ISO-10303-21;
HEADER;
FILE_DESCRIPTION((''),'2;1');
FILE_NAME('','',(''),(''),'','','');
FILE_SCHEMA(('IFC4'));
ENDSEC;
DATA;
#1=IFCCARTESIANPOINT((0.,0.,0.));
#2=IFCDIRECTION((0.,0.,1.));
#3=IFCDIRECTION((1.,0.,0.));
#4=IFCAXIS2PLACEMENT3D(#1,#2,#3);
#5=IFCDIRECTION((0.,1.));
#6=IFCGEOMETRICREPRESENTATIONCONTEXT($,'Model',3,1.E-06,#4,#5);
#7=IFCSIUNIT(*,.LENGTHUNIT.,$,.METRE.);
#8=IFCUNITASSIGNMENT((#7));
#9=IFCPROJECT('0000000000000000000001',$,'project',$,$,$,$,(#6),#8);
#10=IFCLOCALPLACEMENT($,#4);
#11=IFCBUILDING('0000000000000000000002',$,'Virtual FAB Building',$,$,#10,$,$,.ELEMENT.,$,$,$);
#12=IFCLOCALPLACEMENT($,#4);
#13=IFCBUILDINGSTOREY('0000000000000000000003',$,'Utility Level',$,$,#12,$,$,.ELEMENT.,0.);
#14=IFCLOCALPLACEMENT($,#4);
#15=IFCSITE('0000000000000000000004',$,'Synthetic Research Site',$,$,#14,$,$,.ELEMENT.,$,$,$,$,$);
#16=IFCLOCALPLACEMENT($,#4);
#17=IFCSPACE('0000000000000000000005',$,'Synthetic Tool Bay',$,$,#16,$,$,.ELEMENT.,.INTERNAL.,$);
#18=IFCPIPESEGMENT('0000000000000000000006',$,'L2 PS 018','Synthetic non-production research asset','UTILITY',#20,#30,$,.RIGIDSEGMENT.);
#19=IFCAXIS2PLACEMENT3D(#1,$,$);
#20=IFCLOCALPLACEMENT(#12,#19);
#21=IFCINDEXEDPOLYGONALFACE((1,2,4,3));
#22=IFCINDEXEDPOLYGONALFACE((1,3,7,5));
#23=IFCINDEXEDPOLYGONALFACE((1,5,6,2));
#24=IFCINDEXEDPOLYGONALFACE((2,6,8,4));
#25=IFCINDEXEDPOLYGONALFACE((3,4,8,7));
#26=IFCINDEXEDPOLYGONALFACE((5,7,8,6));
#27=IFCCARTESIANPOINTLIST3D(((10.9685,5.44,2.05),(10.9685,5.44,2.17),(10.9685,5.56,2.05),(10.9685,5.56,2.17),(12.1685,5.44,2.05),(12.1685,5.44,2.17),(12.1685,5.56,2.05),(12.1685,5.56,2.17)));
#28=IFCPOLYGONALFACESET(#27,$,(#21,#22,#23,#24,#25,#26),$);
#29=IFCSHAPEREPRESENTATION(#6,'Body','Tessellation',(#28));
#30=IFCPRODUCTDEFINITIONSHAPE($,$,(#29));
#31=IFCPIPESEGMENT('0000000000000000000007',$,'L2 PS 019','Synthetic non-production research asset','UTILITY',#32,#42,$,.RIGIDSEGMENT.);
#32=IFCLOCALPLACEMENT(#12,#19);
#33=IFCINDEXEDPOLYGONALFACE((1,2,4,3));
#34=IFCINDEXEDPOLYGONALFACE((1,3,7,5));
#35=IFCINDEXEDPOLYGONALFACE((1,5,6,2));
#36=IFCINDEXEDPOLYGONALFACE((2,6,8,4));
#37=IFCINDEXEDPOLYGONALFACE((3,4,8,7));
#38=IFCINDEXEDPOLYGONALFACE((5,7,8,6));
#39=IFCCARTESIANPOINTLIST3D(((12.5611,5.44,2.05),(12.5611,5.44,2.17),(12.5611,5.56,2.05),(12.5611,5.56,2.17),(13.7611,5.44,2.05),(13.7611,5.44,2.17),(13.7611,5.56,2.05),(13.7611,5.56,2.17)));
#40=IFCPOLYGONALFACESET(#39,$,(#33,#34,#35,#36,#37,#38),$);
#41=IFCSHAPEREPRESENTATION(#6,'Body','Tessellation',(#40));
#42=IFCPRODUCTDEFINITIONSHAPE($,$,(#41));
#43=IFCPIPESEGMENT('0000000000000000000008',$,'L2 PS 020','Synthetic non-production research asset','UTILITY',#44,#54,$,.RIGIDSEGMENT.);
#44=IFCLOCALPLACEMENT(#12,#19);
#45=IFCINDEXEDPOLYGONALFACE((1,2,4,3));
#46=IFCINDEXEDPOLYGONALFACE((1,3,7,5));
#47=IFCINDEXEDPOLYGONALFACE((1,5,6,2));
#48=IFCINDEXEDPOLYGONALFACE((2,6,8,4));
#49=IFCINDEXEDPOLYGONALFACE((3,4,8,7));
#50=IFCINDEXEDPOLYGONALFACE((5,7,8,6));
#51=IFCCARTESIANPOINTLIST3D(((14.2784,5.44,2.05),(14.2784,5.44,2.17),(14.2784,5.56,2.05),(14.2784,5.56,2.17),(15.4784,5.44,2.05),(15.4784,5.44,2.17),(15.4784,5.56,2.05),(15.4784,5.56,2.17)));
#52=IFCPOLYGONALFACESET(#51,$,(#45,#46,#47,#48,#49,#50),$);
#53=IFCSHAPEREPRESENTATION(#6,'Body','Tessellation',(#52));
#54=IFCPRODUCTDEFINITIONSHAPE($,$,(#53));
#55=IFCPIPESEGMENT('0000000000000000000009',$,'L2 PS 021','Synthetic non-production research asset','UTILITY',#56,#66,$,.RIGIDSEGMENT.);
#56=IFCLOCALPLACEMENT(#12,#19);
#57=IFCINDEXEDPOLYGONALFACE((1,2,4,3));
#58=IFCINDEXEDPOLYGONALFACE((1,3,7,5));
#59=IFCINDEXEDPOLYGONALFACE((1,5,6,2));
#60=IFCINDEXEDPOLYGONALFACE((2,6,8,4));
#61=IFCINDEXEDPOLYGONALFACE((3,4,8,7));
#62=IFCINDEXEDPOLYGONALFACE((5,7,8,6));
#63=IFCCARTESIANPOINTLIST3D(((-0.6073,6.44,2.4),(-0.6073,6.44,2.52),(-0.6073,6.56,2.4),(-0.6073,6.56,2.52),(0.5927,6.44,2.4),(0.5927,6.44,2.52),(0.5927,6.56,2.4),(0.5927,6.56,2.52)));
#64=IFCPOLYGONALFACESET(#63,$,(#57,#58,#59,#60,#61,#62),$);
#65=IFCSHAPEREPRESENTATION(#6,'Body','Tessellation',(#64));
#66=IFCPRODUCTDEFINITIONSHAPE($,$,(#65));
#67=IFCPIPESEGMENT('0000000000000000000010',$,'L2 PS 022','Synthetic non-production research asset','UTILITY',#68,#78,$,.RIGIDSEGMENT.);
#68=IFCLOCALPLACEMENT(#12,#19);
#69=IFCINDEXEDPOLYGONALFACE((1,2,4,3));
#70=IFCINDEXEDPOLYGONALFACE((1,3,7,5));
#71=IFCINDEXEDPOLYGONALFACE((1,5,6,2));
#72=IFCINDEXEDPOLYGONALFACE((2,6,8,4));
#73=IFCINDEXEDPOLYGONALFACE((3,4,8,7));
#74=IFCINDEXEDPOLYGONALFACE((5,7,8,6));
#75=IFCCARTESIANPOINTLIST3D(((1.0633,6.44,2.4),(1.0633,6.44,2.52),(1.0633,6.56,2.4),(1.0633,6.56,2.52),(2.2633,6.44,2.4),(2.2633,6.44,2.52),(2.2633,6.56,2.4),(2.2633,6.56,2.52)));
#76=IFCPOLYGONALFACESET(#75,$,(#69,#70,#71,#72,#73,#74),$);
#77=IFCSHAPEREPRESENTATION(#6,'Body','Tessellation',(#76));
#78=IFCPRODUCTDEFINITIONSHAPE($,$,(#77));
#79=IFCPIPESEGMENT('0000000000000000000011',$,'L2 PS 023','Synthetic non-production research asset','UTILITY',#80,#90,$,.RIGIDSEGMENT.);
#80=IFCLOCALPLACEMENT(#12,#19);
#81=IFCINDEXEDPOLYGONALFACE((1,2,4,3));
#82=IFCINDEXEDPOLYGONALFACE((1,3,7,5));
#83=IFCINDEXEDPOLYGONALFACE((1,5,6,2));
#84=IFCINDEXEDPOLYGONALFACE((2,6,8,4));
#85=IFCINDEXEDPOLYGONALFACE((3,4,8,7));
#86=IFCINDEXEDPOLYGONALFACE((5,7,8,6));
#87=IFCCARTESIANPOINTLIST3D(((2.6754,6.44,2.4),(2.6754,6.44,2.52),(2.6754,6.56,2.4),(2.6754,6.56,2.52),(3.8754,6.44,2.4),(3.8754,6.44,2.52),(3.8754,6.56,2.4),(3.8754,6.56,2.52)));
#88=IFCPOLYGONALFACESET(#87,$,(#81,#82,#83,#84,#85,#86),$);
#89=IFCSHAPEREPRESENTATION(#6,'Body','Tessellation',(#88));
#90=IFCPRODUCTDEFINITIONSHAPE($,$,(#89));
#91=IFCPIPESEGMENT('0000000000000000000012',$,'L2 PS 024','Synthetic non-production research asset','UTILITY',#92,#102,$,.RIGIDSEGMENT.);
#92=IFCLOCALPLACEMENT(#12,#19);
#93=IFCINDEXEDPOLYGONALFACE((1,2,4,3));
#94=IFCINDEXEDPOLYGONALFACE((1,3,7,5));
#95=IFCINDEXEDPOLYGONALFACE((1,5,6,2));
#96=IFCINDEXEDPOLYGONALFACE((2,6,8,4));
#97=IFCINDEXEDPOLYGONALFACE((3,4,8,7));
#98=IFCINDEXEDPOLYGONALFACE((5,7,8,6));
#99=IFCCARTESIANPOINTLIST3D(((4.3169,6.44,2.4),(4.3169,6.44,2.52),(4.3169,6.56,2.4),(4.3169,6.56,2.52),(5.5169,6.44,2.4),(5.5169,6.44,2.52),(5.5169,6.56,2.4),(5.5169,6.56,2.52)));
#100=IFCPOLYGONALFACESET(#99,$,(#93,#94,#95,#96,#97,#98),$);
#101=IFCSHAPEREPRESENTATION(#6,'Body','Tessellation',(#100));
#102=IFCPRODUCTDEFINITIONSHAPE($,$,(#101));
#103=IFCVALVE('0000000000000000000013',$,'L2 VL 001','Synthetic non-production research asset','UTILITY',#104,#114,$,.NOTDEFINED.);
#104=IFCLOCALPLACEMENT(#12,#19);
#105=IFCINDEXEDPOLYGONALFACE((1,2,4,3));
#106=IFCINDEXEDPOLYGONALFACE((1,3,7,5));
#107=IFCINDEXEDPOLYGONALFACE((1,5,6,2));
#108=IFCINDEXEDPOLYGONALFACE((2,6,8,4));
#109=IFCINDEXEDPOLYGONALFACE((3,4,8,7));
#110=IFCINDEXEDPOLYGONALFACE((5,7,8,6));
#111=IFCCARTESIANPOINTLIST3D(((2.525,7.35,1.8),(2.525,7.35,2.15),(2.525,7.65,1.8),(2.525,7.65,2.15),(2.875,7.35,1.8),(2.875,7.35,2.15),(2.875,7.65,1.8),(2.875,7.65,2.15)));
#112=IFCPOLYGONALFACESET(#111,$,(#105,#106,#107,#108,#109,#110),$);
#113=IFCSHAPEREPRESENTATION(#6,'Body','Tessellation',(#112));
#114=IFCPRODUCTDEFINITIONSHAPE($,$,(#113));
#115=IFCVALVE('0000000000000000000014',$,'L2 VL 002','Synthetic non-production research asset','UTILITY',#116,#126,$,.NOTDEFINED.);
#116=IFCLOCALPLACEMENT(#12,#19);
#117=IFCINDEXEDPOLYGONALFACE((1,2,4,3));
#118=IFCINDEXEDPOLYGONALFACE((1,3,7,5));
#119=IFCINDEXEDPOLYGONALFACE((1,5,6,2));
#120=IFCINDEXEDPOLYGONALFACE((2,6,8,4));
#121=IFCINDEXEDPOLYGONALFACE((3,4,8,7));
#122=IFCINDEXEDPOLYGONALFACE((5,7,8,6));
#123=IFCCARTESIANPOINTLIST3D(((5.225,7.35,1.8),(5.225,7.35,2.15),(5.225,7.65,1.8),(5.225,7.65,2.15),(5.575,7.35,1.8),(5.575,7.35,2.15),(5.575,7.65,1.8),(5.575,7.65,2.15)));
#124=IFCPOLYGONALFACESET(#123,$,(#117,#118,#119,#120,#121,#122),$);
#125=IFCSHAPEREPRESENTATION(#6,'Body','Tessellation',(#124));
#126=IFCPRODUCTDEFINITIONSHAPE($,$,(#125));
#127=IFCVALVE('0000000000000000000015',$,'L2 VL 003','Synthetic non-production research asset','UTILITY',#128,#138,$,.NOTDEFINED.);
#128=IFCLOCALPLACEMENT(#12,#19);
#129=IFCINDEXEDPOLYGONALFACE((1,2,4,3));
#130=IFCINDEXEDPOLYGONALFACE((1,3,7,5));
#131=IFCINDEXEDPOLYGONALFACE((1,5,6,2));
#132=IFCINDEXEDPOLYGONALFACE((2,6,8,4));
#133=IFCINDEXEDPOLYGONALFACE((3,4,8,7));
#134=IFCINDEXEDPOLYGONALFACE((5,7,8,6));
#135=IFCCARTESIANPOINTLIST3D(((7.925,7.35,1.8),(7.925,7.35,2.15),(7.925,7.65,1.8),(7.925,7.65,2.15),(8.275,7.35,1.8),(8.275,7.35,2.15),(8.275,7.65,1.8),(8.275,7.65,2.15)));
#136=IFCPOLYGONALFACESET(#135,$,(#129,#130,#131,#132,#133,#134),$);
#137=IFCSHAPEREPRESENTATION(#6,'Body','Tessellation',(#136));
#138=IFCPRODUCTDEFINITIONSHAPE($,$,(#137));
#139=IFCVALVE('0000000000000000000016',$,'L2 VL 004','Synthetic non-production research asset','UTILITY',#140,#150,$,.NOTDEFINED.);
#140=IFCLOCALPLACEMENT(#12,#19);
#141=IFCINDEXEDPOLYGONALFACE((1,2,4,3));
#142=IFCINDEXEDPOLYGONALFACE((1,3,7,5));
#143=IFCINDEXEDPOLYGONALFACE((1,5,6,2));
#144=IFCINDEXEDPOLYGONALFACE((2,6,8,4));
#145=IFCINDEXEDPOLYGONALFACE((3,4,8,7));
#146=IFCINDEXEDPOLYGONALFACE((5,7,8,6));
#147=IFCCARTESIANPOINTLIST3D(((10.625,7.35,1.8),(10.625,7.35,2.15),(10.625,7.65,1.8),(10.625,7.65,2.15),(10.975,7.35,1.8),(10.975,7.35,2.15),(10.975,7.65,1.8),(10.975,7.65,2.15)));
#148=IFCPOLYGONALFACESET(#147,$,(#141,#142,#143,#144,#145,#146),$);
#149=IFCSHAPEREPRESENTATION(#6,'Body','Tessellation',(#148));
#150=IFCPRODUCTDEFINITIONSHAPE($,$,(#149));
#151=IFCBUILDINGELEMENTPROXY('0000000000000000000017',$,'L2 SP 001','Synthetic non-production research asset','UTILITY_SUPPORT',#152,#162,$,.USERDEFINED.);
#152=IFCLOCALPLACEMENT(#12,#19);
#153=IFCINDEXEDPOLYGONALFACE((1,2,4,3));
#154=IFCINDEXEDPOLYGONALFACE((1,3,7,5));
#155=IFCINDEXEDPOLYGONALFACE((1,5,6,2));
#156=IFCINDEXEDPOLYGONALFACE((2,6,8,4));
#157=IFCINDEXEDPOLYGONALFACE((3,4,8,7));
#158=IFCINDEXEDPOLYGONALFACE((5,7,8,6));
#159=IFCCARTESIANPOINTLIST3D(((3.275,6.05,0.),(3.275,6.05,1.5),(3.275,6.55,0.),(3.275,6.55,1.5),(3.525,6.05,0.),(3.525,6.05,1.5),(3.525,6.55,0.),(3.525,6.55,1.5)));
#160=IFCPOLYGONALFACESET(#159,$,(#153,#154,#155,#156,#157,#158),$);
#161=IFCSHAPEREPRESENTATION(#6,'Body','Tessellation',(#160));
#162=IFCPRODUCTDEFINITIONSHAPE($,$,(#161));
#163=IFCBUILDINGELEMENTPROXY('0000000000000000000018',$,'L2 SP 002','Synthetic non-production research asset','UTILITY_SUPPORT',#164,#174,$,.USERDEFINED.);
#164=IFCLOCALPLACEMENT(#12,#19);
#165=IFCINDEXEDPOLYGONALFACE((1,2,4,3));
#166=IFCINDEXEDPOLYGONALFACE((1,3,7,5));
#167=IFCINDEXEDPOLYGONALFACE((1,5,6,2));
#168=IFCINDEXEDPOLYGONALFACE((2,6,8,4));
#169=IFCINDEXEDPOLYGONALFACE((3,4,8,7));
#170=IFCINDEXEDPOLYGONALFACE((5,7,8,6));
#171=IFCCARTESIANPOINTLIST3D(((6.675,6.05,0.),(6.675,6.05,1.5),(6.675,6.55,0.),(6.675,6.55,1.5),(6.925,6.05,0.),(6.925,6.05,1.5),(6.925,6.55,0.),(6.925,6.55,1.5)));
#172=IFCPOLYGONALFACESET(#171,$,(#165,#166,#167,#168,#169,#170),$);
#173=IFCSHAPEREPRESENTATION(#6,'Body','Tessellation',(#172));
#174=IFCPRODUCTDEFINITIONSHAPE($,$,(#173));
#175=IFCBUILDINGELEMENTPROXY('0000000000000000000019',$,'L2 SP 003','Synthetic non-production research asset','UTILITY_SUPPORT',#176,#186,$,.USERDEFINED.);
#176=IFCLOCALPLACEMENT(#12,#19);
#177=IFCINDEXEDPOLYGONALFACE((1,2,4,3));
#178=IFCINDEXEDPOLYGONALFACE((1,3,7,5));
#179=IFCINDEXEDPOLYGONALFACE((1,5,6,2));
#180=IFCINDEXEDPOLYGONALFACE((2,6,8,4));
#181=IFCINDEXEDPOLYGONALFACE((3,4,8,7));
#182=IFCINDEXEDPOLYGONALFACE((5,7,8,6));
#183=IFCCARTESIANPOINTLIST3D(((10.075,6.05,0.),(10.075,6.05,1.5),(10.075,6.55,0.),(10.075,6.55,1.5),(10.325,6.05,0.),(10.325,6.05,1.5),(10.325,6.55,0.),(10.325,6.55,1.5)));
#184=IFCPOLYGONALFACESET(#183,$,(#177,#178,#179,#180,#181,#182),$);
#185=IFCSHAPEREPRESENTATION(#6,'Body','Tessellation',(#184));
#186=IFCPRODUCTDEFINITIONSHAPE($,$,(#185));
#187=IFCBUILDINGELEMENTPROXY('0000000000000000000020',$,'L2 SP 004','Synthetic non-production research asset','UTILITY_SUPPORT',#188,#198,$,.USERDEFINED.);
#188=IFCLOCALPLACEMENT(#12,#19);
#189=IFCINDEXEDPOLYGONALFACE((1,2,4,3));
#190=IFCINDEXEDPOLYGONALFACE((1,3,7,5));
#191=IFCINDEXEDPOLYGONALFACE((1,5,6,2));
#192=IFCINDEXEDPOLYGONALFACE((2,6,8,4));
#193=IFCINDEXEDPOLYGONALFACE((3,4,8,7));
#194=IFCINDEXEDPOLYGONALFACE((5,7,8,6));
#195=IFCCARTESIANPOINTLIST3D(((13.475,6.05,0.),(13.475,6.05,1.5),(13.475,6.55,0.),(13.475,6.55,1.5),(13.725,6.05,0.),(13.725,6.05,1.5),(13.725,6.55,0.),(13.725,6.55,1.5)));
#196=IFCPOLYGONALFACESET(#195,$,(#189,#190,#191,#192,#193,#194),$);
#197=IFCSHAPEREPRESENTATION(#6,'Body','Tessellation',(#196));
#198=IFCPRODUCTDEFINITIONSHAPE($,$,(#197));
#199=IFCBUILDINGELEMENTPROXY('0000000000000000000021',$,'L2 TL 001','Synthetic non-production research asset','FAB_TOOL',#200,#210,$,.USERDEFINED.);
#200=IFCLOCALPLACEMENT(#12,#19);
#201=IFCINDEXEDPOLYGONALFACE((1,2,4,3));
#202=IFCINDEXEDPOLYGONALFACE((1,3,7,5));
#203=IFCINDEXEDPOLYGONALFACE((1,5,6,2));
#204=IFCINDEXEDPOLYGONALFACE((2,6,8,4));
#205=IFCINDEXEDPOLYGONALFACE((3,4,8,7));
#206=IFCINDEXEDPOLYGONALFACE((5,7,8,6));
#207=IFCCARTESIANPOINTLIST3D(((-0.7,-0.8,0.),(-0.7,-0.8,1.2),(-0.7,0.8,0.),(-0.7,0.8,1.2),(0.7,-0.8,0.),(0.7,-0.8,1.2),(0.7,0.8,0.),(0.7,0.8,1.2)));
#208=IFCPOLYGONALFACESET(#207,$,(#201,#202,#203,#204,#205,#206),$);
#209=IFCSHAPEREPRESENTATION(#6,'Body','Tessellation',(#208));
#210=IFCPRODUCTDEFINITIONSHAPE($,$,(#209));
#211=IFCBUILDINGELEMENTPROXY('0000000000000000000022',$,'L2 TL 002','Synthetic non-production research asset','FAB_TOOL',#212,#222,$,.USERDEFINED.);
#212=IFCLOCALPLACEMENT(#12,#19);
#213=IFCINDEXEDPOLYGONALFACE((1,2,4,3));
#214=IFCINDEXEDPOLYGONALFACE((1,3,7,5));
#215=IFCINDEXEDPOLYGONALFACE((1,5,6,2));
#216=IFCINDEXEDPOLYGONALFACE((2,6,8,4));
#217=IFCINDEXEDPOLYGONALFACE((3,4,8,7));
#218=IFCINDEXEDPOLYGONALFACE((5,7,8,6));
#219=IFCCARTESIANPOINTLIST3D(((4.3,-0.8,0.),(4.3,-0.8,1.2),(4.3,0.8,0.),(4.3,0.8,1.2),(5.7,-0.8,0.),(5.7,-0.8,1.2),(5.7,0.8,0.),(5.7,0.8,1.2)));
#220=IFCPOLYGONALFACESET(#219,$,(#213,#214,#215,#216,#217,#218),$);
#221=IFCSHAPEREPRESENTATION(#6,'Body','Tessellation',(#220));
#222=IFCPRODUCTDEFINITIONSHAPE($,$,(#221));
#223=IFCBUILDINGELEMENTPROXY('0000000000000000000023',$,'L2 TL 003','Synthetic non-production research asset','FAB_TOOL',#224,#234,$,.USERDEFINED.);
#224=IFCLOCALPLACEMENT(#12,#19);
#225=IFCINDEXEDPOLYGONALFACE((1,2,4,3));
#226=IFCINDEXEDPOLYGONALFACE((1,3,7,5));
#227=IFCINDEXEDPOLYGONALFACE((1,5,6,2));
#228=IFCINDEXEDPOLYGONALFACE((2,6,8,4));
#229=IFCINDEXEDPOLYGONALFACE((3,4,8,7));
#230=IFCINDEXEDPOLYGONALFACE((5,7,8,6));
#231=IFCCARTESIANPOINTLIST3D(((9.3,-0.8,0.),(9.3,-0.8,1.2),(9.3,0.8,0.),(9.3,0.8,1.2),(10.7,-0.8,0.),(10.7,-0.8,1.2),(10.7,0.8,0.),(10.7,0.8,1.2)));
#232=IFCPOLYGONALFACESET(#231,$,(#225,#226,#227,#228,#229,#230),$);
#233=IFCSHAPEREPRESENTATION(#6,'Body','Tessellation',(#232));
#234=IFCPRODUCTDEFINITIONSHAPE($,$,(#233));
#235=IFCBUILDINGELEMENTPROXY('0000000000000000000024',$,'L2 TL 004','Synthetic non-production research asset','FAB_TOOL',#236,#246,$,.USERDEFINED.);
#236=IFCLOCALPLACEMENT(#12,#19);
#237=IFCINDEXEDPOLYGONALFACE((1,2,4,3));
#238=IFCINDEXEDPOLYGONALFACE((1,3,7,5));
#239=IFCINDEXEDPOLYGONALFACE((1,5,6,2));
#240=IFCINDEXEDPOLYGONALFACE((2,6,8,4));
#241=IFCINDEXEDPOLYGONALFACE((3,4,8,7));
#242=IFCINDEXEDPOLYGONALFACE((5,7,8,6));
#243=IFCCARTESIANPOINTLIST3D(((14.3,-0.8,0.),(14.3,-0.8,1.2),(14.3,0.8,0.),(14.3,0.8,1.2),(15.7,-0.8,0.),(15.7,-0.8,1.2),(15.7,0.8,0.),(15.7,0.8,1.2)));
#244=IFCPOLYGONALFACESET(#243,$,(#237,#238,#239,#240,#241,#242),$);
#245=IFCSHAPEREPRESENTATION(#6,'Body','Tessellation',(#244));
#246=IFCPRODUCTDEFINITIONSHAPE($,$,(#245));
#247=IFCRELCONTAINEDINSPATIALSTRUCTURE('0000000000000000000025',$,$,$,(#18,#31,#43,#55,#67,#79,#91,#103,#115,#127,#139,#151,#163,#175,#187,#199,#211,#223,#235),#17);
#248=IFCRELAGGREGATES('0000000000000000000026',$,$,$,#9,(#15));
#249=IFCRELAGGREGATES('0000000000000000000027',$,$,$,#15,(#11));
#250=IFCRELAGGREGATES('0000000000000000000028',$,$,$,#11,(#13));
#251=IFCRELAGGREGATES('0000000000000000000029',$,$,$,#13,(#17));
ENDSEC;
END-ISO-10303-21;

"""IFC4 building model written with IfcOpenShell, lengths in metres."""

from ifc_helpers import new_model, si_unit, direction, frame, origin_with_axes, origin_2d_with_axis, place, context, project, spatial, rectangle, extrude, element, save


model = new_model("IFC4")

# Units and contexts
model_context = context("Model", 3, precision=1e-06, world=origin_with_axes(), true_north=direction((0.0, 1.0)))
ifc_project = project(units=[si_unit("LENGTHUNIT", "METRE")], contexts=[model_context])

# Site, building, storey, space
site_placement = place(None, origin_with_axes())
site = spatial("IfcSite", under=ifc_project, at=site_placement, Name="Synthetic Research Site", CompositionType="ELEMENT")
building_placement = place(None, origin_with_axes())
building = spatial("IfcBuilding", under=site, at=building_placement, Name="Virtual FAB Building", CompositionType="ELEMENT")
storey_placement = place(None, origin_with_axes())
storey = spatial("IfcBuildingStorey", under=building, at=storey_placement, Name="Utility Level", CompositionType="ELEMENT", Elevation=0.0)
space_placement = place(None, origin_with_axes())
space = spatial("IfcSpace", under=storey, at=space_placement, Name="Synthetic Tool Bay", CompositionType="ELEMENT", PredefinedType="INTERNAL")

# Pipe segments
for number, where, z_axis, x_axis, name in (
    (1, (11.5685, 5.5, 2.05), (0.0, 0.0, 1.0), (1.0, 0.0, 0.0), "L2 PS 018"),
    (2, (13.1611, 5.5, 2.05), (0.0, 0.0, 1.0), (1.0, 0.0, 0.0), "L2 PS 019"),
    (3, (14.8783, 5.5, 2.05), (0.0, 0.0, 1.0), (1.0, 0.0, 0.0), "L2 PS 020"),
    (4, (-0.0073, 6.5, 2.4), (0.0, 0.0, 1.0), (1.0, 0.0, 0.0), "L2 PS 021"),
    (5, (1.6633, 6.5, 2.4), (0.0, 0.0, 1.0), (1.0, 0.0, 0.0), "L2 PS 022"),
    (6, (3.2754, 6.5, 2.4), (0.0, 0.0, 1.0), (1.0, 0.0, 0.0), "L2 PS 023"),
    (7, (4.9169, 6.5, 2.4), (0.0, 0.0, 1.0), (1.0, 0.0, 0.0), "L2 PS 024"),
):
    element("IfcPipeSegment", number, at=place(None, frame(where, z_axis=z_axis, x_axis=x_axis)), inside=space, Name=name, Description="Synthetic non-production research asset", ObjectType="UTILITY", PredefinedType="RIGIDSEGMENT", context=model_context, shape_type="SweptSolid", body=[
        extrude(rectangle(XDim=1.2, YDim=0.12, at=origin_2d_with_axis()), origin_with_axes(), (0.0, 0.0, 1.0), 0.12),
    ])

# Valves
for number, where, z_axis, x_axis, name in (
    (8, (2.7, 7.5, 1.8), (0.0, 0.0, 1.0), (1.0, 0.0, 0.0), "L2 VL 001"),
    (9, (5.4, 7.5, 1.8), (0.0, 0.0, 1.0), (1.0, 0.0, 0.0), "L2 VL 002"),
    (10, (8.1, 7.5, 1.8), (0.0, 0.0, 1.0), (1.0, 0.0, 0.0), "L2 VL 003"),
    (11, (10.8, 7.5, 1.8), (0.0, 0.0, 1.0), (1.0, 0.0, 0.0), "L2 VL 004"),
):
    element("IfcValve", number, at=place(None, frame(where, z_axis=z_axis, x_axis=x_axis)), inside=space, Name=name, Description="Synthetic non-production research asset", ObjectType="UTILITY", PredefinedType="NOTDEFINED", context=model_context, shape_type="SweptSolid", body=[
        extrude(rectangle(XDim=0.35, YDim=0.3, at=origin_2d_with_axis()), origin_with_axes(), (0.0, 0.0, 1.0), 0.35),
    ])

# Building element proxies
for number, where, z_axis, x_axis, name in (
    (12, (3.4, 6.3, 0.0), (0.0, 0.0, 1.0), (1.0, 0.0, 0.0), "L2 SP 001"),
    (13, (6.8, 6.3, 0.0), (0.0, 0.0, 1.0), (1.0, 0.0, 0.0), "L2 SP 002"),
    (14, (10.2, 6.3, 0.0), (0.0, 0.0, 1.0), (1.0, 0.0, 0.0), "L2 SP 003"),
    (15, (13.6, 6.3, 0.0), (0.0, 0.0, 1.0), (1.0, 0.0, 0.0), "L2 SP 004"),
):
    element("IfcBuildingElementProxy", number, at=place(None, frame(where, z_axis=z_axis, x_axis=x_axis)), inside=space, Name=name, Description="Synthetic non-production research asset", ObjectType="UTILITY_SUPPORT", PredefinedType="USERDEFINED", context=model_context, shape_type="SweptSolid", body=[
        extrude(rectangle(XDim=0.25, YDim=0.5, at=origin_2d_with_axis()), origin_with_axes(), (0.0, 0.0, 1.0), 1.5),
    ])
for number, where, z_axis, x_axis, name in (
    (16, (0.0, 0.0, 0.0), (0.0, 0.0, 1.0), (1.0, 0.0, 0.0), "L2 TL 001"),
    (17, (5.0, 0.0, 0.0), (0.0, 0.0, 1.0), (1.0, 0.0, 0.0), "L2 TL 002"),
    (18, (10.0, 0.0, 0.0), (0.0, 0.0, 1.0), (1.0, 0.0, 0.0), "L2 TL 003"),
    (19, (15.0, 0.0, 0.0), (0.0, 0.0, 1.0), (1.0, 0.0, 0.0), "L2 TL 004"),
):
    element("IfcBuildingElementProxy", number, at=place(None, frame(where, z_axis=z_axis, x_axis=x_axis)), inside=space, Name=name, Description="Synthetic non-production research asset", ObjectType="FAB_TOOL", PredefinedType="USERDEFINED", context=model_context, shape_type="SweptSolid", body=[
        extrude(rectangle(XDim=1.4, YDim=1.6, at=origin_2d_with_axis()), origin_with_axes(), (0.0, 0.0, 1.0), 1.2),
    ])

save(model, "model.ifc")
